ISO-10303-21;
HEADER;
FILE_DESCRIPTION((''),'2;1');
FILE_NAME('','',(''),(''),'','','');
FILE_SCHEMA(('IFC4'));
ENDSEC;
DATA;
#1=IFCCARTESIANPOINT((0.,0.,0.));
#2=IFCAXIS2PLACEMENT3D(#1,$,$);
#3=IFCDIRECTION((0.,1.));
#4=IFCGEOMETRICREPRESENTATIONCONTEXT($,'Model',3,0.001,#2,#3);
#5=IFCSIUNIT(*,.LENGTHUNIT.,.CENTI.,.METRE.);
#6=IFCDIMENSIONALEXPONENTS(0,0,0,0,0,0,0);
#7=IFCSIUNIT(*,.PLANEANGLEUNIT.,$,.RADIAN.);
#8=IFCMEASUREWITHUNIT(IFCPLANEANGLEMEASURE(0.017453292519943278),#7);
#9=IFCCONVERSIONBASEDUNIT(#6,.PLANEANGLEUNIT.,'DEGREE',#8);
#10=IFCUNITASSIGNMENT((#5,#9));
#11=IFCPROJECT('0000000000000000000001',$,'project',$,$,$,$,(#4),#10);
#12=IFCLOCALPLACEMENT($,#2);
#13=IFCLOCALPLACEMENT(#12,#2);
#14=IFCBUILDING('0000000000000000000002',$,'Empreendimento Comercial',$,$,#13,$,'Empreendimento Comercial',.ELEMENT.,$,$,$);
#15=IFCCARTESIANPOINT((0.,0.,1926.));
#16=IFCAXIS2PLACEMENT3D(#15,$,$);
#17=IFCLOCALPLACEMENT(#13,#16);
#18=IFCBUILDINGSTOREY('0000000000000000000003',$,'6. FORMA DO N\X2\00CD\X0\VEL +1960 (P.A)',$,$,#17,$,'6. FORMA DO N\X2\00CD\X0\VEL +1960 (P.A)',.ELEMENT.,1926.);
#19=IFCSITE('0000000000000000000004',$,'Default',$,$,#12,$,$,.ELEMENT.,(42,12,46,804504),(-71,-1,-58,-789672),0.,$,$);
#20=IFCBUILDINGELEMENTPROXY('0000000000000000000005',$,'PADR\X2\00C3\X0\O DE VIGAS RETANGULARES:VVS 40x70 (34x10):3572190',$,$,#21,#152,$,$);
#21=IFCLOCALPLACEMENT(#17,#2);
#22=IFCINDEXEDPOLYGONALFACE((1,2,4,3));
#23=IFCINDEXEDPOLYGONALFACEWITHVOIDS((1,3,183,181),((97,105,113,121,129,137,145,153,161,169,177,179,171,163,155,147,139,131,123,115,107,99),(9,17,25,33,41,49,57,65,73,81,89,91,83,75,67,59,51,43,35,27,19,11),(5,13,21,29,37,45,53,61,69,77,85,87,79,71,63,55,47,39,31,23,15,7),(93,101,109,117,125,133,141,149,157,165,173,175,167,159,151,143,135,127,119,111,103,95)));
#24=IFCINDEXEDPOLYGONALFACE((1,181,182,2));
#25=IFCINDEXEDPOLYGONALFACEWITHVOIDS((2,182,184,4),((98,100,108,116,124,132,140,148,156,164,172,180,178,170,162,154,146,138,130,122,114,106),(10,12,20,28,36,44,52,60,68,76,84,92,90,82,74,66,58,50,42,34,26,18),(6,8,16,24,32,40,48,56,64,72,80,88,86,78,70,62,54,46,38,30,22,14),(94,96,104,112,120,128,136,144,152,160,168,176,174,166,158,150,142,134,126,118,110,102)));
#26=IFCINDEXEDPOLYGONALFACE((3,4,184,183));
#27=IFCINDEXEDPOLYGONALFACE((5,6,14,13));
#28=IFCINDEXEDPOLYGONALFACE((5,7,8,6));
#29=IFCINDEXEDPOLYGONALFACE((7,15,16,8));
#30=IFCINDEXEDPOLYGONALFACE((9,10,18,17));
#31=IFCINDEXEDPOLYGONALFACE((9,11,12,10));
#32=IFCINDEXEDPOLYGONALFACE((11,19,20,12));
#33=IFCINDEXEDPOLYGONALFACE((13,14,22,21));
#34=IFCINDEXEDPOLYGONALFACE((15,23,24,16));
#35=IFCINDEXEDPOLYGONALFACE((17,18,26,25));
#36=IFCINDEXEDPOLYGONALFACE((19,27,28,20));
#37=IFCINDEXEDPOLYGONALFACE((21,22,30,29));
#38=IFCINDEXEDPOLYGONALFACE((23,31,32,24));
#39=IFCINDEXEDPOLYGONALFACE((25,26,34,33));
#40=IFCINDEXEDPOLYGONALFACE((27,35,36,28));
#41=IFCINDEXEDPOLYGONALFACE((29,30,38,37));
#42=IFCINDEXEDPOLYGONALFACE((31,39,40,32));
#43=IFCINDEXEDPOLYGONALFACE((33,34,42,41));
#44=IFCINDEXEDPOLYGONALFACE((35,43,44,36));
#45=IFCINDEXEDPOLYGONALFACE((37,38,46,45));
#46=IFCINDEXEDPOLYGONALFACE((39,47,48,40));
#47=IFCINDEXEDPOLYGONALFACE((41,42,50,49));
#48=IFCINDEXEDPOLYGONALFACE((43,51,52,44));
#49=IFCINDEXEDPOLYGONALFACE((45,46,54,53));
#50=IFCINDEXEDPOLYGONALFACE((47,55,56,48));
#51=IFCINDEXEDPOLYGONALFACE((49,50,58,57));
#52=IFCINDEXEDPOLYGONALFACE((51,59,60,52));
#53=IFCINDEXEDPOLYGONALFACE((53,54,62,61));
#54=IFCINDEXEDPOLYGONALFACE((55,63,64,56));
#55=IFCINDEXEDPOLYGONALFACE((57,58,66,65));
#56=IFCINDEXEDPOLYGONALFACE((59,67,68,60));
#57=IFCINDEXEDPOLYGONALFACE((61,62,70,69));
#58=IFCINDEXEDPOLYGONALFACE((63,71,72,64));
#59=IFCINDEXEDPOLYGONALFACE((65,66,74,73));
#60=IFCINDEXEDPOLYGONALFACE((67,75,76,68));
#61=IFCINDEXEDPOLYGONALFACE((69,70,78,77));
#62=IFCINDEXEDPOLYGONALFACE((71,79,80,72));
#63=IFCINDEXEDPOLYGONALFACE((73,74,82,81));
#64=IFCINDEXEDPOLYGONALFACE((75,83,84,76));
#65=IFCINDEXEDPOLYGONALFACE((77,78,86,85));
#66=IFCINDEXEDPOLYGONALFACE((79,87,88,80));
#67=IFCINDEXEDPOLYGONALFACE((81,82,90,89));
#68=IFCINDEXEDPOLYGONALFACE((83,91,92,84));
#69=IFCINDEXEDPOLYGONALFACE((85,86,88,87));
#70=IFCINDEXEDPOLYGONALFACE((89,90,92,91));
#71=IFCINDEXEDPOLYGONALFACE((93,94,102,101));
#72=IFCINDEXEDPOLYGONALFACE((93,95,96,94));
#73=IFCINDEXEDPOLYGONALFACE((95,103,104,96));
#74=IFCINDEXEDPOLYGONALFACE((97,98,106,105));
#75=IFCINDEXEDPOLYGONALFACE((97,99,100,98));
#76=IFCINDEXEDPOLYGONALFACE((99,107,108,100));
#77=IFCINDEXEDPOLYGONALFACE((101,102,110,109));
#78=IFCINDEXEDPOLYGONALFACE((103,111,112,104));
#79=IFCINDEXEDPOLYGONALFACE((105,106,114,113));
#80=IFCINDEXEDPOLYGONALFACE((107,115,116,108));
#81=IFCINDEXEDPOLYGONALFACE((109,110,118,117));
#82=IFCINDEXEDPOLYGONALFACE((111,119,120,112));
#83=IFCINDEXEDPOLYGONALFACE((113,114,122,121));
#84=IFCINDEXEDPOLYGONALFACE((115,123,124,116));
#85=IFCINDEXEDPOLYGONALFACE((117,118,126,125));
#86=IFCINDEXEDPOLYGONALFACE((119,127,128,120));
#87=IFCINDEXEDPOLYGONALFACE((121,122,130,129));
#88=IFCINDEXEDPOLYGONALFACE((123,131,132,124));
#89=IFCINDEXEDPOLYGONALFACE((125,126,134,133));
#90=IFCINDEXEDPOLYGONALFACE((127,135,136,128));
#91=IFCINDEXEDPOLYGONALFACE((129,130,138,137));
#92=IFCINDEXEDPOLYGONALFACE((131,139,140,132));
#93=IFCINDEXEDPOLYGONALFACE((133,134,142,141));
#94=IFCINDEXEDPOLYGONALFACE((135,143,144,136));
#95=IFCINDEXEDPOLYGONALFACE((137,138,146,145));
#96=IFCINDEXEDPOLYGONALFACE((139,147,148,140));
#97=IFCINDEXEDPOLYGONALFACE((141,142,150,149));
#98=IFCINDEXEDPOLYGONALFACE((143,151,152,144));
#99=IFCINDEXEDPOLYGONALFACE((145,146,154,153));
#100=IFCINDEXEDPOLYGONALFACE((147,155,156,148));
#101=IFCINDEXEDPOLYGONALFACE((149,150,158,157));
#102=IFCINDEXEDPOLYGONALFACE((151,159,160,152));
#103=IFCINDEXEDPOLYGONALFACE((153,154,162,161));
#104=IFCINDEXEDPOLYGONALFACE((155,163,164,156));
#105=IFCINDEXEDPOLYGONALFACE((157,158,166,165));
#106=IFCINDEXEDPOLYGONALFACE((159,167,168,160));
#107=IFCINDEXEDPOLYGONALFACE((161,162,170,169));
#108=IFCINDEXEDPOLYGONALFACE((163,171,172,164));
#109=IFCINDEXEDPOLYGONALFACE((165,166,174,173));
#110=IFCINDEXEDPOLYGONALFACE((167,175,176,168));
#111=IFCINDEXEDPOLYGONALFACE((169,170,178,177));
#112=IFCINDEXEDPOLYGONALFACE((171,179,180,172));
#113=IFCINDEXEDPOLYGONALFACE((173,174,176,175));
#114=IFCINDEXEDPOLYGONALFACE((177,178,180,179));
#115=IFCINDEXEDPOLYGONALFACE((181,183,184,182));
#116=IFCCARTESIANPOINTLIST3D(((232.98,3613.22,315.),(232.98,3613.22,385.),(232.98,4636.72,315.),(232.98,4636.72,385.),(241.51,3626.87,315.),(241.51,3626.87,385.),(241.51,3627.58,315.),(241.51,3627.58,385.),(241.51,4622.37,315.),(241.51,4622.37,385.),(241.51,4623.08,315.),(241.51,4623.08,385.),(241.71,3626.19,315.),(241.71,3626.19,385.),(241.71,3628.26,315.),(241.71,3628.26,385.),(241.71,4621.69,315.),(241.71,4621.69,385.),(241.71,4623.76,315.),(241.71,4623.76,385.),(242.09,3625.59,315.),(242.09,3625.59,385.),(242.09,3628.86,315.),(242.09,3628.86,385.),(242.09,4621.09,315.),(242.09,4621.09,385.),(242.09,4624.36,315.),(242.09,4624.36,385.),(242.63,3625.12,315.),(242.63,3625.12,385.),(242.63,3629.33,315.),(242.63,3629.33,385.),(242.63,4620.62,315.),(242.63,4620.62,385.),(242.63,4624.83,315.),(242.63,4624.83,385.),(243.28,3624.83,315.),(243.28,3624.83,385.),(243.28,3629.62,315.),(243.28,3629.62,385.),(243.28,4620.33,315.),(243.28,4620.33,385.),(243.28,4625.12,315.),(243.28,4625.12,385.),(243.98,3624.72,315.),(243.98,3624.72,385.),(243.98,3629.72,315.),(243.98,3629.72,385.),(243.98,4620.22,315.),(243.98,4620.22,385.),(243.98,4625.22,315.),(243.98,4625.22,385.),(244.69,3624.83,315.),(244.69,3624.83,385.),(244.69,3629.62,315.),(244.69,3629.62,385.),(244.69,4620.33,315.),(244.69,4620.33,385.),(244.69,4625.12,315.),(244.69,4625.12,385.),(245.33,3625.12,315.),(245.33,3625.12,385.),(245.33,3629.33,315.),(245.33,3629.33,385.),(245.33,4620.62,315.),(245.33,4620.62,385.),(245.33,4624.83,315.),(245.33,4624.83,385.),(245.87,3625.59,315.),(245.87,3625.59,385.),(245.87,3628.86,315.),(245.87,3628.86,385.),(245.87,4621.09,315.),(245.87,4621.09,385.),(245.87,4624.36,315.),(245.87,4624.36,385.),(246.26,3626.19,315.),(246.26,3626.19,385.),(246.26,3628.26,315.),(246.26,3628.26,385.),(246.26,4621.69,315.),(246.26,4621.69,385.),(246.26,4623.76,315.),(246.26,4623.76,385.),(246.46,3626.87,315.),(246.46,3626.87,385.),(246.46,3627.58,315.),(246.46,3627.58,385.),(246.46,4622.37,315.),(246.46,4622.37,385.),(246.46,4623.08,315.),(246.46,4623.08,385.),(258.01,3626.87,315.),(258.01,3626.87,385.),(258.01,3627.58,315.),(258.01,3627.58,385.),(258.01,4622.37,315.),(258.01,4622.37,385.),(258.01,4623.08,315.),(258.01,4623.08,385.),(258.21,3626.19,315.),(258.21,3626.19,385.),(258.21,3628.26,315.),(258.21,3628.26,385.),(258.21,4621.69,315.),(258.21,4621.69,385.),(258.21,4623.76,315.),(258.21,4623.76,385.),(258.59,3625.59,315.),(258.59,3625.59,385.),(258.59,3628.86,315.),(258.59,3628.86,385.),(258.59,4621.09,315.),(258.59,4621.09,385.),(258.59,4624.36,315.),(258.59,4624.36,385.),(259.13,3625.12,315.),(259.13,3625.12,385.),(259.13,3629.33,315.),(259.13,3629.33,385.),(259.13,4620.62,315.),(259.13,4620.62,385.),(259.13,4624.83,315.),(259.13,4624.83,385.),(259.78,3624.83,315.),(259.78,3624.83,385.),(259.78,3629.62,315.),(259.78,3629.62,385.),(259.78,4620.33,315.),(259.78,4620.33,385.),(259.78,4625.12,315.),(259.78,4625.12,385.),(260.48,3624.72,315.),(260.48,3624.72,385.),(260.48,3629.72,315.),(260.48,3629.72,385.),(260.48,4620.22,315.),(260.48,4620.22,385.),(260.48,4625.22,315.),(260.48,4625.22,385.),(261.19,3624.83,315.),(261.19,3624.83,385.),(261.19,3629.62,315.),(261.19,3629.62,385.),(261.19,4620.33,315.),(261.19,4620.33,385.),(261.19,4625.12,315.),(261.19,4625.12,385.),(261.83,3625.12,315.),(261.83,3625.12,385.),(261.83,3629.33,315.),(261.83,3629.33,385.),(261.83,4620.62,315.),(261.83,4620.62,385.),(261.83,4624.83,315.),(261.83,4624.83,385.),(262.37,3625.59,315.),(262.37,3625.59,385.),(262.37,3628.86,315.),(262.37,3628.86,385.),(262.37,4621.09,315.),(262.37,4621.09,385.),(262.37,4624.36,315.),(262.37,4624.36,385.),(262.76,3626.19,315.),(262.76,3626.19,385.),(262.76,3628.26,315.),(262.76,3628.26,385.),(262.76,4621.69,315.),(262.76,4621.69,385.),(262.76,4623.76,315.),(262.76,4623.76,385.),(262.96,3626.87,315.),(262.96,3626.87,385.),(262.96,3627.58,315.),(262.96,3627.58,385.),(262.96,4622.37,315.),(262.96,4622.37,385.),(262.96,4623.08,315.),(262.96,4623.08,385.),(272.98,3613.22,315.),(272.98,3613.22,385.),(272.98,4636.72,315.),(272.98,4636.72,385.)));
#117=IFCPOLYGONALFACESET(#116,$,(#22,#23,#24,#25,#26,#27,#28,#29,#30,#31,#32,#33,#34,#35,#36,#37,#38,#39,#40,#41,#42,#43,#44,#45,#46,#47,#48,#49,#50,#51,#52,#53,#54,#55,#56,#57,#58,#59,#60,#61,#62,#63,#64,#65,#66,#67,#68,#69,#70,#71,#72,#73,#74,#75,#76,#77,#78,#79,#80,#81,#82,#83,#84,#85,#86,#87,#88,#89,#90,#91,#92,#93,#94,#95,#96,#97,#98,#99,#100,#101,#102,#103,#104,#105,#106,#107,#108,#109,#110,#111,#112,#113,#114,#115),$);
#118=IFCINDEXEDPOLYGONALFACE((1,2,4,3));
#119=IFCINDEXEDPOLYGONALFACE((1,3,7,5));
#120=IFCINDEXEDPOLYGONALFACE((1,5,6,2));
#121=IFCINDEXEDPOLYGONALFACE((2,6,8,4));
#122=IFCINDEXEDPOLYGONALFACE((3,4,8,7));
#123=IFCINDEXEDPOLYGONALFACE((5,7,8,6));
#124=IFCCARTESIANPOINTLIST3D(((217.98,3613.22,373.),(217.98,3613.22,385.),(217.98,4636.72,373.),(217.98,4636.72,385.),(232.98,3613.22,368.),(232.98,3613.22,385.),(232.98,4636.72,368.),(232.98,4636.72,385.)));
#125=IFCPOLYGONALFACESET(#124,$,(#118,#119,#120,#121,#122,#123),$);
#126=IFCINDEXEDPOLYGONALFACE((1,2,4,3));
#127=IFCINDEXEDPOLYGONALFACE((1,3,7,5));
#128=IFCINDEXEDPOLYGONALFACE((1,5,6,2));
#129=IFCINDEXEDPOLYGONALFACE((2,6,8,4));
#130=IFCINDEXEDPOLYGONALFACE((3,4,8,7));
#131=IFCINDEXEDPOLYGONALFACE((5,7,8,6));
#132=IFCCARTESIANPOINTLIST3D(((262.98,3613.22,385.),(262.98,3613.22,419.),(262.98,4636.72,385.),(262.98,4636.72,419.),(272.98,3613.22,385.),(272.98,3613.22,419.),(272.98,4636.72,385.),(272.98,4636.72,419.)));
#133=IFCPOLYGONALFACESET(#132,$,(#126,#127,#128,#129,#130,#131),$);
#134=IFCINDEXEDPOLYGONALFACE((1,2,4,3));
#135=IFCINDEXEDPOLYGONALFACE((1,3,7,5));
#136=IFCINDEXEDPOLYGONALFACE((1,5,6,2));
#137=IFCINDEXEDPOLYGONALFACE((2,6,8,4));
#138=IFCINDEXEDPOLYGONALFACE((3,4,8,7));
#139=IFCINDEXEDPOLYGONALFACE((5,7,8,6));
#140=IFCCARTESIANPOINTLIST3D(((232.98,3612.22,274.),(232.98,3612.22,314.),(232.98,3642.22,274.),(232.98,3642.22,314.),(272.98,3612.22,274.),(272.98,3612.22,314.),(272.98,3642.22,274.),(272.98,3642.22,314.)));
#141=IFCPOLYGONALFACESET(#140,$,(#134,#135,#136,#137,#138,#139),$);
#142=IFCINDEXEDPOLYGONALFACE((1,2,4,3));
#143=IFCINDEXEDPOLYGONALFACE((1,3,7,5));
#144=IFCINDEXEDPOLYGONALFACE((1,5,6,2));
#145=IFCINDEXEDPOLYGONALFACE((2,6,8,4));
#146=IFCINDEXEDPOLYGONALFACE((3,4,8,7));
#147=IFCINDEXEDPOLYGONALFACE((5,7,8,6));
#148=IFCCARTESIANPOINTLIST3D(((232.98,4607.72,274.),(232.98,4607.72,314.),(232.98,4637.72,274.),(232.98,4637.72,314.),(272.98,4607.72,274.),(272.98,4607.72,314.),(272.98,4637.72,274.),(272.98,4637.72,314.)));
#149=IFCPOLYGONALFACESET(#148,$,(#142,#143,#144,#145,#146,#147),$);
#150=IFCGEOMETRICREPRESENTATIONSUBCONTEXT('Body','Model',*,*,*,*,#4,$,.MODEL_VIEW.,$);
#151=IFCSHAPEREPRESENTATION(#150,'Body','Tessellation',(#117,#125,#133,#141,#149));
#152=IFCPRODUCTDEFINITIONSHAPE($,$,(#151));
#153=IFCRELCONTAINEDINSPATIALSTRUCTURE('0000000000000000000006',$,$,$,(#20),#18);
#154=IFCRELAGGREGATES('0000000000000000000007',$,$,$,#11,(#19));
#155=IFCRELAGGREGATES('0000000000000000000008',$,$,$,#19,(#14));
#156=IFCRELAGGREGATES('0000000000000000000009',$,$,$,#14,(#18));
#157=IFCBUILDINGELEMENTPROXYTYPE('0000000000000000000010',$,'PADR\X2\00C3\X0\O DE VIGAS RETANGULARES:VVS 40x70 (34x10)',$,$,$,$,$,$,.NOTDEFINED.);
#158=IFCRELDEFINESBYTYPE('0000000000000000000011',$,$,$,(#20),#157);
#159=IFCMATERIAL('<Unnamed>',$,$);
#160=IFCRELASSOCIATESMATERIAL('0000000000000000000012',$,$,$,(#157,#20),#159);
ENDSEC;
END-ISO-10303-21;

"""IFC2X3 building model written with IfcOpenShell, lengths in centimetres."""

from ifc_helpers import new_model, entity, si_unit, converted_unit, direction, frame, frame_2d, origin, place, context, subcontext, project, spatial, polyline, circle_curve, parameter, trimmed, segment, composite_curve, rectangle, outline, extrude, source, transform, mapped, material, type_object, type_shapes, element, save


model = new_model("IFC2X3")

# Units and contexts
model_context = context("Model", 3, precision=0.001, world=origin(), true_north=direction((0.0, 1.0)))
body_context = subcontext(model_context, "Body", "Model", "MODEL_VIEW")
ifc_project = project(units=[si_unit("LENGTHUNIT", "METRE", prefix="CENTI"), converted_unit("PLANEANGLEUNIT", "DEGREE", entity("IfcPlaneAngleMeasure", 0.017453292519943278), si_unit("PLANEANGLEUNIT", "RADIAN"), dimensions=[0, 0, 0, 0, 0, 0, 0])], contexts=[model_context])

# Site, building, storey
site_placement = place(None, origin())
site = spatial("IfcSite", under=ifc_project, at=site_placement, Name="Default", CompositionType="ELEMENT", RefLatitude=(42, 12, 46, 804504), RefLongitude=(-71, -1, -58, -789672), RefElevation=0.0)
building_placement = place(site_placement, origin())
building = spatial("IfcBuilding", under=site, at=building_placement, Name="Empreendimento Comercial", LongName="Empreendimento Comercial", CompositionType="ELEMENT")
storey_placement = place(building_placement, frame((0.0, 0.0, 1926.0)))
storey = spatial("IfcBuildingStorey", under=building, at=storey_placement, Name="6. FORMA DO NÍVEL +1960 (P.A)", LongName="6. FORMA DO NÍVEL +1960 (P.A)", CompositionType="ELEMENT", Elevation=1926.0)

# Building element proxy
ifc_material = material(Name="<Unnamed>")
building_element_proxy_type_1 = type_object("IfcBuildingElementProxyType", Name="PADRÃO DE VIGAS RETANGULARES:VVS 40x70 (34x10)", PredefinedType="NOTDEFINED", material=ifc_material)
shared_shape_1 = source(origin(), body_context, "Body", "SweptSolid", [
    extrude(outline(polyline([(-20.0, -511.75), (20.0, -511.75), (20.0, 511.75), (-20.0, 511.75), (-20.0, -511.75)]), holes=[composite_curve([segment(trimmed(circle_curve(frame_2d((9.0, 497.75), x_axis=(0.0, -1.0)), 2.5), [parameter(0.0)], [parameter(180.0)], True, "PARAMETER"), False, "CONTINUOUS"), segment(trimmed(circle_curve(frame_2d((9.0, 497.75), x_axis=(0.0, -1.0)), 2.5), [parameter(180.0)], [parameter(0.0)], True, "PARAMETER"), False, "CONTINUOUS")], self_intersect=False), composite_curve([segment(trimmed(circle_curve(frame_2d((-7.5, 497.75), x_axis=(0.0, -1.0)), 2.5), [parameter(0.0)], [parameter(180.0)], True, "PARAMETER"), False, "CONTINUOUS"), segment(trimmed(circle_curve(frame_2d((-7.5, 497.75), x_axis=(0.0, -1.0)), 2.5), [parameter(180.0)], [parameter(0.0)], True, "PARAMETER"), False, "CONTINUOUS")], self_intersect=False), composite_curve([segment(trimmed(circle_curve(frame_2d((-7.5, -497.75), x_axis=(0.0, -1.0)), 2.5), [parameter(0.0)], [parameter(180.0)], True, "PARAMETER"), False, "CONTINUOUS"), segment(trimmed(circle_curve(frame_2d((-7.5, -497.75), x_axis=(0.0, -1.0)), 2.5), [parameter(180.0)], [parameter(0.0)], True, "PARAMETER"), False, "CONTINUOUS")], self_intersect=False), composite_curve([segment(trimmed(circle_curve(frame_2d((9.0, -497.75), x_axis=(0.0, -1.0)), 2.5), [parameter(0.0)], [parameter(180.0)], True, "PARAMETER"), False, "CONTINUOUS"), segment(trimmed(circle_curve(frame_2d((9.0, -497.75), x_axis=(0.0, -1.0)), 2.5), [parameter(180.0)], [parameter(0.0)], True, "PARAMETER"), False, "CONTINUOUS")], self_intersect=False)]), frame((252.98, 4124.97, 2241.0), z_axis=(0.0, 0.0, 1.0), x_axis=(-1.0, 0.0, 0.0)), (0.0, 0.0, 1.0), 70.0),
    extrude(outline(polyline([(-7.5, -7.25), (7.5, -7.25), (7.5, 9.75), (-7.5, 4.75), (-7.5, -7.25)])), frame((225.48, 3613.22, 2303.75), z_axis=(0.0, 1.0, 0.0), x_axis=(1.0, 0.0, 0.0)), (0.0, 0.0, 1.0), 1023.5),
    extrude(rectangle(XDim=10.0, YDim=1023.5, at=frame_2d((0.0, 0.0), x_axis=(1.0, 0.0))), frame((267.98, 4124.97, 2311.0), z_axis=(0.0, 0.0, 1.0), x_axis=(-1.0, 0.0, 0.0)), (0.0, 0.0, 1.0), 34.0),
    extrude(rectangle(XDim=30.0, YDim=40.0, at=frame_2d((0.0, 0.0), x_axis=(1.0, 0.0))), frame((252.98, 3627.22, 2200.0), z_axis=(0.0, 0.0, 1.0), x_axis=(0.0, -1.0, 0.0)), (0.0, 0.0, 1.0), 40.0),
    extrude(rectangle(XDim=30.0, YDim=40.0, at=frame_2d((0.0, 0.0), x_axis=(1.0, 0.0))), frame((252.98, 4622.72, 2200.0), z_axis=(0.0, 0.0, 1.0), x_axis=(0.0, -1.0, 0.0)), (0.0, 0.0, 1.0), 40.0),
])
type_shapes(building_element_proxy_type_1, [shared_shape_1])
proxy_1_placement = place(storey_placement, frame((0.0, 0.0, -1926.0)))
element("IfcBuildingElementProxy", 1, at=proxy_1_placement, inside=storey, type_object=building_element_proxy_type_1, material=ifc_material, Name="PADRÃO DE VIGAS RETANGULARES:VVS 40x70 (34x10):3572190", context=body_context, shape_type="MappedRepresentation", body=[
    mapped(shared_shape_1, transform((0.0, 0.0, 0.0), scale=1.0)),
])

save(model, "model.ifc")
